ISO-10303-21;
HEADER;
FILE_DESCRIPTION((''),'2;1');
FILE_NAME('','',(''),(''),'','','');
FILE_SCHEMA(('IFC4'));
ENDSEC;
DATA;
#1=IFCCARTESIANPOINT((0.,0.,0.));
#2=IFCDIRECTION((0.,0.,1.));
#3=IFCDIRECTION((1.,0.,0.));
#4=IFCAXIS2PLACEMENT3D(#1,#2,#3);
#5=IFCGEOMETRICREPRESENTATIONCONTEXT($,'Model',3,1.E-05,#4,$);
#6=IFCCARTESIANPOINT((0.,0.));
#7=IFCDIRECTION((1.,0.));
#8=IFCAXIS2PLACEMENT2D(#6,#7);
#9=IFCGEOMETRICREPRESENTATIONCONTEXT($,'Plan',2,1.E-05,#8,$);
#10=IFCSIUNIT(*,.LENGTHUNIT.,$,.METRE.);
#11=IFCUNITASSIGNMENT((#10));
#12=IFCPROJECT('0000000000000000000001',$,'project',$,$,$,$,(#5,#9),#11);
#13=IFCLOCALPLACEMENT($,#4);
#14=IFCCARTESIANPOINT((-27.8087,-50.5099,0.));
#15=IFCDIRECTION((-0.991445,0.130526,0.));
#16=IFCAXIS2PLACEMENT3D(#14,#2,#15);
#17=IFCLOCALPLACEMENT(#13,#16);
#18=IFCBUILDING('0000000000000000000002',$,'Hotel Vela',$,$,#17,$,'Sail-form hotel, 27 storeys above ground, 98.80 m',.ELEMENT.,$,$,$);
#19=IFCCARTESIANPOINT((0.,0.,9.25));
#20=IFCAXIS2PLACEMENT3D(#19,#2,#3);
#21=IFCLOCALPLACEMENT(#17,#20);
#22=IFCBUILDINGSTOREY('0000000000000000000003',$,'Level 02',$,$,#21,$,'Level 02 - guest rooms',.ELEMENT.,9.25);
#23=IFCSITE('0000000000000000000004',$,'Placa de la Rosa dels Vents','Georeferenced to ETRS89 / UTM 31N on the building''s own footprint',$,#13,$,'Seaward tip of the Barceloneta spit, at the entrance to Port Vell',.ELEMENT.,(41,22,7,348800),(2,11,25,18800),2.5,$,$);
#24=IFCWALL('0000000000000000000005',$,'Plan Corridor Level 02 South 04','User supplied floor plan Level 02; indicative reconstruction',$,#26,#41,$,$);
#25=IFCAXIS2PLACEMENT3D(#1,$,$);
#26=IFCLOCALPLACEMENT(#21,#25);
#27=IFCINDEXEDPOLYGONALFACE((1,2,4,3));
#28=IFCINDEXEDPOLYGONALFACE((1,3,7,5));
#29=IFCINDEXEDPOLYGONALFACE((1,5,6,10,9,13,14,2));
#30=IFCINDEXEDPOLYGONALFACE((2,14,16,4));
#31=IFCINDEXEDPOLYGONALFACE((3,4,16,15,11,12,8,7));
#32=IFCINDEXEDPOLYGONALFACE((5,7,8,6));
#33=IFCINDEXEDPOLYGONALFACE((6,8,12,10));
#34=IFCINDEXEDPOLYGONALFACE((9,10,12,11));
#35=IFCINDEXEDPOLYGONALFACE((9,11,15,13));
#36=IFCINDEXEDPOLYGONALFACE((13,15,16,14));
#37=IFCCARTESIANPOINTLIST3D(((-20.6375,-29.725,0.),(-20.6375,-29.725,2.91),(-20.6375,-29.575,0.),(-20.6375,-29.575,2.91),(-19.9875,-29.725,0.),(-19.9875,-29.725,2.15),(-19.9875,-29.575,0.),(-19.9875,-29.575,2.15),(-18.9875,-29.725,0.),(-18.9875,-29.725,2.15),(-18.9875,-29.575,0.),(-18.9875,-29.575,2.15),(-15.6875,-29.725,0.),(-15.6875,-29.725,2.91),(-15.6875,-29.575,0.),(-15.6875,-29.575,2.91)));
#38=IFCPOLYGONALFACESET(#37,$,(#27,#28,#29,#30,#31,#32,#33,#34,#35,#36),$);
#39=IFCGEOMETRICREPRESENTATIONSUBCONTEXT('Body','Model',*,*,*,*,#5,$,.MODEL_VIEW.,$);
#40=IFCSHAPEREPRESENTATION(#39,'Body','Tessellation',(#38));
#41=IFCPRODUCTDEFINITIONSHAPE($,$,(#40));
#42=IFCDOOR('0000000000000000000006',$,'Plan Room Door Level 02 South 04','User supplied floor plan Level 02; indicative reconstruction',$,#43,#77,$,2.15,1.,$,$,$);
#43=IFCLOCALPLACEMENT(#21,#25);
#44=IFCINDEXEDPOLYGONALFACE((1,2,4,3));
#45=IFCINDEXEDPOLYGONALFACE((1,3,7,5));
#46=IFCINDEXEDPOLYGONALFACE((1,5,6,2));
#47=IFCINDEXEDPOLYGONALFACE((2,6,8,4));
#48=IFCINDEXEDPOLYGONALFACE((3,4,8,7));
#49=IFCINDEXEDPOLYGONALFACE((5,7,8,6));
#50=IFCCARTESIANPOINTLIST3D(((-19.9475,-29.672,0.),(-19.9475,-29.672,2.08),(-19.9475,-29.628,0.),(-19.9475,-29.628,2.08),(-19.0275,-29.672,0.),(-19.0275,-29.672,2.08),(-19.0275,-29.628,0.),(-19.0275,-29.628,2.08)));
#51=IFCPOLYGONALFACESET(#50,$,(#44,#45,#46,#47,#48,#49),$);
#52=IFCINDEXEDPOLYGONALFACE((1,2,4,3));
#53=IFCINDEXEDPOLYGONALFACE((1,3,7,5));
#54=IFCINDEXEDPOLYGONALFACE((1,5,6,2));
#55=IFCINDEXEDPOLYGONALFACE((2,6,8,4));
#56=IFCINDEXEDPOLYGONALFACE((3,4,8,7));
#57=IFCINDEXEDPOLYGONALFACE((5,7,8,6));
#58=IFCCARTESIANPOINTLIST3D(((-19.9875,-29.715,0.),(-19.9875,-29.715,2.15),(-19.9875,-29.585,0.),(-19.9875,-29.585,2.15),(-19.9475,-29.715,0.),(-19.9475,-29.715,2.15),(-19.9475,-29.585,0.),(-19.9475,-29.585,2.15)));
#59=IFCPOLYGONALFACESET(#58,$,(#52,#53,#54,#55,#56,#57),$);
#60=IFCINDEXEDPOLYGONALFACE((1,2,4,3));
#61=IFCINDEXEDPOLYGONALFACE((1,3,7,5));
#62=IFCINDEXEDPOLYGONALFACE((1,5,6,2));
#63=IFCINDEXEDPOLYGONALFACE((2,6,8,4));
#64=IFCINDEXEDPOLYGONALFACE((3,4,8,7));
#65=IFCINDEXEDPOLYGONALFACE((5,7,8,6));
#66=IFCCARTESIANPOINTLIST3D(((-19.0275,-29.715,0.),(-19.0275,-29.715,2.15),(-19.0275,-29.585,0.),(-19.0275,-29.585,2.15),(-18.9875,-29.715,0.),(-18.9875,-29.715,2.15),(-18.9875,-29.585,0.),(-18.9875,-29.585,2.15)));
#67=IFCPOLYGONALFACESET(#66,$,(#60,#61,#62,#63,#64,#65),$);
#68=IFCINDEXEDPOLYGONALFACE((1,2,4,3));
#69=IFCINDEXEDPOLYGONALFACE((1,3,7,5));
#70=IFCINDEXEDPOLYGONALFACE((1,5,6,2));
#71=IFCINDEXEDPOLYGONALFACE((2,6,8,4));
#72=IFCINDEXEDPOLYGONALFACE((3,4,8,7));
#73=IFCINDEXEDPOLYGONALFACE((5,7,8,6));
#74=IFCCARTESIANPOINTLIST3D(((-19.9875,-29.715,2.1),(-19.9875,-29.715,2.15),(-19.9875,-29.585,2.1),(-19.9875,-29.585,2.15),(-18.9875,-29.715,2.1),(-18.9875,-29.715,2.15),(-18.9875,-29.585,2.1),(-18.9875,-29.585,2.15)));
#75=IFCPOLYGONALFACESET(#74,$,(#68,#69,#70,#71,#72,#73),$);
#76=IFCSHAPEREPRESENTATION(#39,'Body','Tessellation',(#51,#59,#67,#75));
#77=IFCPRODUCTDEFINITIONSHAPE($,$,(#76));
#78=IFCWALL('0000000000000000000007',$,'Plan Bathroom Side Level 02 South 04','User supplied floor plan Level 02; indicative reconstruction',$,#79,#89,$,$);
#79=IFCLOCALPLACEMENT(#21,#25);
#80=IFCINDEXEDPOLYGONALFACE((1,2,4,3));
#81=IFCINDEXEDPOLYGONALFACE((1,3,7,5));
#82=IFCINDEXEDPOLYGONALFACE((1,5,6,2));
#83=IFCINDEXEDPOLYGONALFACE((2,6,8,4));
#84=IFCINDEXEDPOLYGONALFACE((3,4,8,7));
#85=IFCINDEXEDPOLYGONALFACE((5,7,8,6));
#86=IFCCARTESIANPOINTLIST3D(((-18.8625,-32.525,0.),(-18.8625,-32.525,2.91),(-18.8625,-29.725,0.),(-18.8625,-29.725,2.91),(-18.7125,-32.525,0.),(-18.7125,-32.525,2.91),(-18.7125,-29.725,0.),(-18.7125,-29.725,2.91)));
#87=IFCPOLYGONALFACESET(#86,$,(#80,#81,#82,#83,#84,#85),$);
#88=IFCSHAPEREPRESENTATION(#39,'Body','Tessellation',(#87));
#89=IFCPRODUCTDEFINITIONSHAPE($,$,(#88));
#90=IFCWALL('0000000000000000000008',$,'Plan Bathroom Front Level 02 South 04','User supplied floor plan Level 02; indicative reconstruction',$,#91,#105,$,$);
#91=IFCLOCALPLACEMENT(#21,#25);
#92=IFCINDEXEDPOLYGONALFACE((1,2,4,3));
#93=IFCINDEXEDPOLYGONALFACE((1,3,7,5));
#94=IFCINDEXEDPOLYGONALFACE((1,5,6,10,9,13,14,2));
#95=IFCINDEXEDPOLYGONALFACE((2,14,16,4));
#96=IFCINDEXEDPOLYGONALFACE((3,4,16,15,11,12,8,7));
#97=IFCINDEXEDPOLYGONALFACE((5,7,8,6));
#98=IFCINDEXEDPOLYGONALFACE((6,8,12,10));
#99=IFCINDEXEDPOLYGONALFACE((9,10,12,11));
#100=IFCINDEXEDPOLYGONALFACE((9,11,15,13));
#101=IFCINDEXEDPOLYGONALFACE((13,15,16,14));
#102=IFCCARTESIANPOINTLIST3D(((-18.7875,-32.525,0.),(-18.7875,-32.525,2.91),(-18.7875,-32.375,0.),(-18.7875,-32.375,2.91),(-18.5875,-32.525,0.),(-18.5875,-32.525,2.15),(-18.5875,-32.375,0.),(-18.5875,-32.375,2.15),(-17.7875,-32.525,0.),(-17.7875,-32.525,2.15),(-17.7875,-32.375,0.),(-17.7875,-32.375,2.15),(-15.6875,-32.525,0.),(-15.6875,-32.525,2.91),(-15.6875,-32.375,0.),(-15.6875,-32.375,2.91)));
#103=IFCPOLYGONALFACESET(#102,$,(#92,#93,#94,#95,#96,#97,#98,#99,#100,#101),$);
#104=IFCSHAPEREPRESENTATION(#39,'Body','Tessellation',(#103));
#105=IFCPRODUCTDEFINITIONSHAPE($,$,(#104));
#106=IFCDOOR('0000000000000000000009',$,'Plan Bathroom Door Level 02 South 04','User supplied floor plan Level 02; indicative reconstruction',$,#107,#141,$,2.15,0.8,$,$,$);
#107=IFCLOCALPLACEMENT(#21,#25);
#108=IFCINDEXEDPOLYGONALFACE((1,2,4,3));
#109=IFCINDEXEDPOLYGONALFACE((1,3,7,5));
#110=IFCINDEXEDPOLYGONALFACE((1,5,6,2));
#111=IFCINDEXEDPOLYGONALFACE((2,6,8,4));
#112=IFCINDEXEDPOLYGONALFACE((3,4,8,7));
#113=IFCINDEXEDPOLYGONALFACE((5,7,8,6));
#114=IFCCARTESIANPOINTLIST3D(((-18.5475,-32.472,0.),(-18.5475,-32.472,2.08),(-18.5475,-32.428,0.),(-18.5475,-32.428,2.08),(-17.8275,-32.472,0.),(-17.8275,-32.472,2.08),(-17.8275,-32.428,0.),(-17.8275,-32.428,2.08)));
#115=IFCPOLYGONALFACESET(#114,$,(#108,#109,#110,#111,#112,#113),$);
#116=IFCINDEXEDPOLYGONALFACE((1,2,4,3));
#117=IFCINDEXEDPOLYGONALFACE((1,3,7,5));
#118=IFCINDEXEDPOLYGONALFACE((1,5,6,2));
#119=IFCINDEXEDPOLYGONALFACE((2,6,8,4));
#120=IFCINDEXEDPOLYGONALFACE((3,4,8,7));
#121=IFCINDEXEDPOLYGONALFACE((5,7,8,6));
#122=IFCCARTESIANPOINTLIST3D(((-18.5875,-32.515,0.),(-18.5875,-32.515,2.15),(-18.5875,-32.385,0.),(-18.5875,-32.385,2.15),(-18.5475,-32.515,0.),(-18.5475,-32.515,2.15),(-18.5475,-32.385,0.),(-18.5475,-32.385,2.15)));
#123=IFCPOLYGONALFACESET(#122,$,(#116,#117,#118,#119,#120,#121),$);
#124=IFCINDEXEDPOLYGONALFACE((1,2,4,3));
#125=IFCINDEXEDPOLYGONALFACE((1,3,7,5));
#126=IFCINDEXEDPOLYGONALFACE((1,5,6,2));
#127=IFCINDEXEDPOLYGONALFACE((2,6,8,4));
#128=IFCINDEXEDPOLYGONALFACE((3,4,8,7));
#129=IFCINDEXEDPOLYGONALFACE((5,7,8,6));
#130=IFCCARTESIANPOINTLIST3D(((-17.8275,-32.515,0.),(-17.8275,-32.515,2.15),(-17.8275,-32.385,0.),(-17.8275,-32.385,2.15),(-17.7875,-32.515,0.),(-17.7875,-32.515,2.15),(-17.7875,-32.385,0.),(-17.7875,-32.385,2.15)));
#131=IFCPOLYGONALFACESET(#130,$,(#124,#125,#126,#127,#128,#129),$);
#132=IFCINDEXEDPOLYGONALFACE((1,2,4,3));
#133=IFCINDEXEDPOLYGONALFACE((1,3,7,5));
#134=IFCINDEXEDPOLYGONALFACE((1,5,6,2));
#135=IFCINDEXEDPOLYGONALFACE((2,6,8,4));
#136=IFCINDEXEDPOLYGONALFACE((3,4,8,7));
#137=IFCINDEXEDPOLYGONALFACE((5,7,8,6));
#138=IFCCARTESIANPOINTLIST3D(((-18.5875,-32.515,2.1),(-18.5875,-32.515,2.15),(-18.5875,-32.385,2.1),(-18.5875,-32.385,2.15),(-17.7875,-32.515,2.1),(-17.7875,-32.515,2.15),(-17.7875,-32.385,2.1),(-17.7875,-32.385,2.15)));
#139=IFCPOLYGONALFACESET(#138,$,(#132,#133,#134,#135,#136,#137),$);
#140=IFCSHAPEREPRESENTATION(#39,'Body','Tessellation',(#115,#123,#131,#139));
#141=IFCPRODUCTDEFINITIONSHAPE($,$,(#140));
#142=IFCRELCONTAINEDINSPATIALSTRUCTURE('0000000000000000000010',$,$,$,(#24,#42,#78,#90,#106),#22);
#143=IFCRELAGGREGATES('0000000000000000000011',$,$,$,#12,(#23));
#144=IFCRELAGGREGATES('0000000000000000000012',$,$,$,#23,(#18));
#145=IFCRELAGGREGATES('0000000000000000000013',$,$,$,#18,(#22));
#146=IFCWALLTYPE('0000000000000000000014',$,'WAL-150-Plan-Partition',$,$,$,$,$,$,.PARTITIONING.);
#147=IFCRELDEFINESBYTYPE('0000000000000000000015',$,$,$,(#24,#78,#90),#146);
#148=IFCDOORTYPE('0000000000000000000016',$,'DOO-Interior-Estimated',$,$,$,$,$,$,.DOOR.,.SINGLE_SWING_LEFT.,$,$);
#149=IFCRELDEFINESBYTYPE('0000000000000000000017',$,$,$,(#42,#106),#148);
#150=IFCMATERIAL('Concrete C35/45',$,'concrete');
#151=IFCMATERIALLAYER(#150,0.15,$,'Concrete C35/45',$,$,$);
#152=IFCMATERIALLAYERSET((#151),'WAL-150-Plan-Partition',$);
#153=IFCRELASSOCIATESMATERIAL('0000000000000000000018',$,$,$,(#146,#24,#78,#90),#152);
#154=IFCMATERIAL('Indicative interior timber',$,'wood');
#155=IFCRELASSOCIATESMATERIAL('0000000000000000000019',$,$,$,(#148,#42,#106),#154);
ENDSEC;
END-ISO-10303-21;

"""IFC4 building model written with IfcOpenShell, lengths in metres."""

from ifc_helpers import new_model, si_unit, frame, origin_with_axes, origin_2d_with_axis, place, context, subcontext, project, spatial, line, indexed_curve, outline, extrude, material, layer, layer_set, layer_usage, type_object, element, fill, save


model = new_model("IFC4")

# Units and contexts
model_context = context("Model", 3, precision=1e-05, world=origin_with_axes())
plan_context = context("Plan", 2, precision=1e-05, world=origin_2d_with_axis())
body_context = subcontext(model_context, "Body", "Model", "MODEL_VIEW")
ifc_project = project(units=[si_unit("LENGTHUNIT", "METRE")], contexts=[model_context, plan_context])

# Site, building, storey
site_placement = place(None, origin_with_axes())
site = spatial("IfcSite", under=ifc_project, at=site_placement, Name="Placa de la Rosa dels Vents", Description="Georeferenced to ETRS89 / UTM 31N on the building's own footprint", LongName="Seaward tip of the Barceloneta spit, at the entrance to Port Vell", CompositionType="ELEMENT", RefLatitude=(41, 22, 7, 348800), RefLongitude=(2, 11, 25, 18800), RefElevation=2.5)
building_placement = place(site_placement, frame((-27.8087, -50.5099, 0.0), z_axis=(0.0, 0.0, 1.0), x_axis=(-0.991445, 0.130526, 0.0)))
building = spatial("IfcBuilding", under=site, at=building_placement, Name="Hotel Vela", LongName="Sail-form hotel, 27 storeys above ground, 98.80 m", CompositionType="ELEMENT")
storey_placement = place(building_placement, frame((0.0, 0.0, 9.25), z_axis=(0.0, 0.0, 1.0), x_axis=(1.0, 0.0, 0.0)))
storey = spatial("IfcBuildingStorey", under=building, at=storey_placement, Name="Level 02", LongName="Level 02 - guest rooms", CompositionType="ELEMENT", Elevation=9.25)

# Shared definitions
ifc_material_1 = material(Name="Concrete C35/45", Category="concrete")
ifc_layer = layer(ifc_material_1, 0.15, Name="Concrete C35/45")
ifc_layer_set = layer_set([ifc_layer], Name="WAL-150-Plan-Partition")
wall_type = type_object("IfcWallType", Name="WAL-150-Plan-Partition", PredefinedType="PARTITIONING", material=ifc_layer_set)
ifc_material_2 = material(Name="Indicative interior timber", Category="wood")
door_type = type_object("IfcDoorType", Name="DOO-Interior-Estimated", OperationType="SINGLE_SWING_LEFT", PredefinedType="DOOR", material=ifc_material_2)

# Wall, opening, door
ifc_layer_usage_1 = layer_usage(ifc_layer_set, "AXIS2", "POSITIVE", 0.0)
wall_1_placement = place(storey_placement, frame((-20.6375, -29.725, 0.0), z_axis=(0.0, 0.0, 1.0), x_axis=(1.0, 0.0, 0.0)))
wall_1 = element("IfcWall", 1, at=wall_1_placement, inside=storey, type_object=wall_type, material=ifc_layer_usage_1, Name="Plan Corridor Level 02 South 04", Description="User supplied floor plan Level 02; indicative reconstruction", context=body_context, shape_type="SweptSolid", body=[
    extrude(outline(indexed_curve([(0.0, 0.0), (4.95, 0.0), (4.95, 0.15), (0.0, 0.15)], segments=[line(1, 2, 3, 4, 1)])), origin_with_axes(), (0.0, 0.0, 1.0), 2.91),
])
opening_1_placement = place(wall_1_placement, frame((0.65, -0.085, 0.0), z_axis=(0.0, 0.0, 1.0), x_axis=(1.0, 0.0, 0.0)))
opening_1 = element("IfcOpeningElement", 2, at=opening_1_placement, cuts=wall_1, PredefinedType="OPENING", context=body_context, shape_type="SweptSolid", body=[
    extrude(outline(indexed_curve([(0.0, 0.0), (1.0, 0.0), (1.0, 0.32), (0.0, 0.32)], segments=[line(1, 2, 3, 4, 1)])), origin_with_axes(), (0.0, 0.0, 1.0), 2.15),
])
door_1_placement = place(storey_placement, frame((0.0, 0.0, -9.25), z_axis=(0.0, 0.0, 1.0), x_axis=(1.0, 0.0, 0.0)))
door_1 = element("IfcDoor", 3, at=door_1_placement, inside=storey, type_object=door_type, material=ifc_material_2, Name="Plan Room Door Level 02 South 04", Description="User supplied floor plan Level 02; indicative reconstruction", OverallHeight=2.15, OverallWidth=1.0, context=body_context, shape_type="SweptSolid", body=[
    extrude(outline(indexed_curve([(0.0, 0.0), (0.92, 0.0), (0.92, 0.044), (0.0, 0.044)], segments=[line(1, 2, 3, 4, 1)])), frame((-19.9475, -29.672, 9.25), z_axis=(0.0, 0.0, 1.0), x_axis=(1.0, 0.0, 0.0)), (0.0, 0.0, 1.0), 2.08),
    extrude(outline(indexed_curve([(0.0, 0.0), (0.04, 0.0), (0.04, 0.13), (0.0, 0.13)], segments=[line(1, 2, 3, 4, 1)])), frame((-19.9875, -29.715, 9.25), z_axis=(0.0, 0.0, 1.0), x_axis=(1.0, 0.0, 0.0)), (0.0, 0.0, 1.0), 2.15),
    extrude(outline(indexed_curve([(0.0, 0.0), (0.04, 0.0), (0.04, 0.13), (0.0, 0.13)], segments=[line(1, 2, 3, 4, 1)])), frame((-19.0275, -29.715, 9.25), z_axis=(0.0, 0.0, 1.0), x_axis=(1.0, 0.0, 0.0)), (0.0, 0.0, 1.0), 2.15),
    extrude(outline(indexed_curve([(0.0, 0.0), (1.0, 0.0), (1.0, 0.13), (0.0, 0.13)], segments=[line(1, 2, 3, 4, 1)])), frame((-19.9875, -29.715, 11.35), z_axis=(0.0, 0.0, 1.0), x_axis=(1.0, 0.0, 0.0)), (0.0, 0.0, 1.0), 0.05),
])
fill(opening_1, door_1)

# Wall
ifc_layer_usage_2 = layer_usage(ifc_layer_set, "AXIS2", "POSITIVE", 0.0)
wall_2_placement = place(storey_placement, frame((-18.8625, -32.525, 0.0), z_axis=(0.0, 0.0, 1.0), x_axis=(1.0, 0.0, 0.0)))
element("IfcWall", 4, at=wall_2_placement, inside=storey, type_object=wall_type, material=ifc_layer_usage_2, Name="Plan Bathroom Side Level 02 South 04", Description="User supplied floor plan Level 02; indicative reconstruction", context=body_context, shape_type="SweptSolid", body=[
    extrude(outline(indexed_curve([(0.0, 0.0), (0.15, 0.0), (0.15, 2.8), (0.0, 2.8)], segments=[line(1, 2, 3, 4, 1)])), origin_with_axes(), (0.0, 0.0, 1.0), 2.91),
])

# Wall, opening, door
ifc_layer_usage_3 = layer_usage(ifc_layer_set, "AXIS2", "POSITIVE", 0.0)
wall_3_placement = place(storey_placement, frame((-18.7875, -32.525, 0.0), z_axis=(0.0, 0.0, 1.0), x_axis=(1.0, 0.0, 0.0)))
wall_3 = element("IfcWall", 5, at=wall_3_placement, inside=storey, type_object=wall_type, material=ifc_layer_usage_3, Name="Plan Bathroom Front Level 02 South 04", Description="User supplied floor plan Level 02; indicative reconstruction", context=body_context, shape_type="SweptSolid", body=[
    extrude(outline(indexed_curve([(0.0, 0.0), (3.1, 0.0), (3.1, 0.15), (0.0, 0.15)], segments=[line(1, 2, 3, 4, 1)])), origin_with_axes(), (0.0, 0.0, 1.0), 2.91),
])
opening_2_placement = place(wall_3_placement, frame((0.2, -0.085, 0.0), z_axis=(0.0, 0.0, 1.0), x_axis=(1.0, 0.0, 0.0)))
opening_2 = element("IfcOpeningElement", 6, at=opening_2_placement, cuts=wall_3, PredefinedType="OPENING", context=body_context, shape_type="SweptSolid", body=[
    extrude(outline(indexed_curve([(0.0, 0.0), (0.8, 0.0), (0.8, 0.32), (0.0, 0.32)], segments=[line(1, 2, 3, 4, 1)])), origin_with_axes(), (0.0, 0.0, 1.0), 2.15),
])
door_2_placement = place(storey_placement, frame((0.0, 0.0, -9.25), z_axis=(0.0, 0.0, 1.0), x_axis=(1.0, 0.0, 0.0)))
door_2 = element("IfcDoor", 7, at=door_2_placement, inside=storey, type_object=door_type, material=ifc_material_2, Name="Plan Bathroom Door Level 02 South 04", Description="User supplied floor plan Level 02; indicative reconstruction", OverallHeight=2.15, OverallWidth=0.8, context=body_context, shape_type="SweptSolid", body=[
    extrude(outline(indexed_curve([(0.0, 0.0), (0.72, 0.0), (0.72, 0.044), (0.0, 0.044)], segments=[line(1, 2, 3, 4, 1)])), frame((-18.5475, -32.472, 9.25), z_axis=(0.0, 0.0, 1.0), x_axis=(1.0, 0.0, 0.0)), (0.0, 0.0, 1.0), 2.08),
    extrude(outline(indexed_curve([(0.0, 0.0), (0.04, 0.0), (0.04, 0.13), (0.0, 0.13)], segments=[line(1, 2, 3, 4, 1)])), frame((-18.5875, -32.515, 9.25), z_axis=(0.0, 0.0, 1.0), x_axis=(1.0, 0.0, 0.0)), (0.0, 0.0, 1.0), 2.15),
    extrude(outline(indexed_curve([(0.0, 0.0), (0.04, 0.0), (0.04, 0.13), (0.0, 0.13)], segments=[line(1, 2, 3, 4, 1)])), frame((-17.8275, -32.515, 9.25), z_axis=(0.0, 0.0, 1.0), x_axis=(1.0, 0.0, 0.0)), (0.0, 0.0, 1.0), 2.15),
    extrude(outline(indexed_curve([(0.0, 0.0), (0.8, 0.0), (0.8, 0.13), (0.0, 0.13)], segments=[line(1, 2, 3, 4, 1)])), frame((-18.5875, -32.515, 11.35), z_axis=(0.0, 0.0, 1.0), x_axis=(1.0, 0.0, 0.0)), (0.0, 0.0, 1.0), 0.05),
])
fill(opening_2, door_2)

save(model, "model.ifc")
